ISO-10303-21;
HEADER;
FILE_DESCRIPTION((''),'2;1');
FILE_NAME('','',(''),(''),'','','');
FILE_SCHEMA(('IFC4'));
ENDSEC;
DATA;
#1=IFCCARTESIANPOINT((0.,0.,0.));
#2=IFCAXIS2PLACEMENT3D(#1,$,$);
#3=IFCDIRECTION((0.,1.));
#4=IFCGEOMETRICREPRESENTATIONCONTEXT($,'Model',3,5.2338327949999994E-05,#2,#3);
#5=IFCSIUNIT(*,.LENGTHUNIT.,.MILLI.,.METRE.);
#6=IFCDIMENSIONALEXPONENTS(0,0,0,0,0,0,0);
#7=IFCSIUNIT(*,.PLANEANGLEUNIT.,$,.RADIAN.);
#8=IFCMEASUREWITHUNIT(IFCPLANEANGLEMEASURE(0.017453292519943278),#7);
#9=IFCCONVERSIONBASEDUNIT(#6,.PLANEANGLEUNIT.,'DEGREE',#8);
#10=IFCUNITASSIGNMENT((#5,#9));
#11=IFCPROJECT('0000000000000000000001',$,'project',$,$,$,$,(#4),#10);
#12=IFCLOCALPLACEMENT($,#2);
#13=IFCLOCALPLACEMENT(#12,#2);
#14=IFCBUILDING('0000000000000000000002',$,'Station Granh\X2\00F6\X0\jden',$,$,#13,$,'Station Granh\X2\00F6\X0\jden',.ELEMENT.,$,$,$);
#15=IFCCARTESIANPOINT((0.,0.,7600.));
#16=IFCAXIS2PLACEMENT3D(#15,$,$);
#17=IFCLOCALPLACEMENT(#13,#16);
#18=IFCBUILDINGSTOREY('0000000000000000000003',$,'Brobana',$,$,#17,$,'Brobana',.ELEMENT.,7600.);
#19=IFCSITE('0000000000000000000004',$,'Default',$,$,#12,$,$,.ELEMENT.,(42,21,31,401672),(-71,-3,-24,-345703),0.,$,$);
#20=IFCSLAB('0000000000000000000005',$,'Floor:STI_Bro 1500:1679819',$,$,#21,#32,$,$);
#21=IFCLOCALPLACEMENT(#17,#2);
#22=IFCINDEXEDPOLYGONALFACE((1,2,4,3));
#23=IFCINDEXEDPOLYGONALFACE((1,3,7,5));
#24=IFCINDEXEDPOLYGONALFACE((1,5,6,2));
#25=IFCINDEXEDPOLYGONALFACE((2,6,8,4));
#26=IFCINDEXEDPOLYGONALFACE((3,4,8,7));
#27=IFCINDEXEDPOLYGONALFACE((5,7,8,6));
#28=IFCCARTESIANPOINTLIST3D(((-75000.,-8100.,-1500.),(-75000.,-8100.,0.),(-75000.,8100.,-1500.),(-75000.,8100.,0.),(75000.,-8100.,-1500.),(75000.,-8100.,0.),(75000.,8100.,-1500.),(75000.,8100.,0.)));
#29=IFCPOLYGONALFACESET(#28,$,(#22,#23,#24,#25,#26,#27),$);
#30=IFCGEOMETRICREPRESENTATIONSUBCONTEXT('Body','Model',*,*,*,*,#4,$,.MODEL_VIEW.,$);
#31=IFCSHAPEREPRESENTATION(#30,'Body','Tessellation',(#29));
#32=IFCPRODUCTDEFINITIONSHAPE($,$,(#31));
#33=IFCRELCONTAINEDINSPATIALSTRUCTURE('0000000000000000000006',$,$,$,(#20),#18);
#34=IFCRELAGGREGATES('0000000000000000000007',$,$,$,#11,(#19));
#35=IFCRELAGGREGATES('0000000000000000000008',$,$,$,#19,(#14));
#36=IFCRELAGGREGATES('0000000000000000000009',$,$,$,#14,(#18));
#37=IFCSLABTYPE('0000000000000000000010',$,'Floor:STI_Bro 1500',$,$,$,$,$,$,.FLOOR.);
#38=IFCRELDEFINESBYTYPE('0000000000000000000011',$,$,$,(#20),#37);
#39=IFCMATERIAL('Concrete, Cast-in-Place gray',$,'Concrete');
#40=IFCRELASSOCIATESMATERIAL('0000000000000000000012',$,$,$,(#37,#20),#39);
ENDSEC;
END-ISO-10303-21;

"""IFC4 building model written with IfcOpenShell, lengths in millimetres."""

from ifc_helpers import new_model, entity, si_unit, converted_unit, direction, frame, origin, place, context, subcontext, project, spatial, indexed_curve, outline, extrude, material, type_object, element, save


model = new_model("IFC4")

# Units and contexts
model_context = context("Model", 3, precision=5.2338327949999994e-05, world=origin(), true_north=direction((0.0, 1.0)))
body_context = subcontext(model_context, "Body", "Model", "MODEL_VIEW")
ifc_project = project(units=[si_unit("LENGTHUNIT", "METRE", prefix="MILLI"), converted_unit("PLANEANGLEUNIT", "DEGREE", entity("IfcPlaneAngleMeasure", 0.017453292519943278), si_unit("PLANEANGLEUNIT", "RADIAN"), dimensions=[0, 0, 0, 0, 0, 0, 0])], contexts=[model_context])

# Site, building, storey
site_placement = place(None, origin())
site = spatial("IfcSite", under=ifc_project, at=site_placement, Name="Default", CompositionType="ELEMENT", RefLatitude=(42, 21, 31, 401672), RefLongitude=(-71, -3, -24, -345703), RefElevation=0.0)
building_placement = place(site_placement, origin())
building = spatial("IfcBuilding", under=site, at=building_placement, Name="Station Granhöjden", LongName="Station Granhöjden", CompositionType="ELEMENT")
storey_placement = place(building_placement, frame((0.0, 0.0, 7600.0)))
storey = spatial("IfcBuildingStorey", under=building, at=storey_placement, Name="Brobana", LongName="Brobana", CompositionType="ELEMENT", Elevation=7600.0)

# Slab
ifc_material = material(Name="Concrete, Cast-in-Place gray", Category="Concrete")
slab_type = type_object("IfcSlabType", Name="Floor:STI_Bro 1500", PredefinedType="FLOOR", material=ifc_material)
slab_placement = place(storey_placement, origin())
element("IfcSlab", 1, at=slab_placement, inside=storey, type_object=slab_type, material=ifc_material, Name="Floor:STI_Bro 1500:1679819", context=body_context, shape_type="SweptSolid", body=[
    extrude(outline(indexed_curve([(-8100.0, -75000.0), (8100.0, -75000.0), (8100.0, 75000.0), (-8100.0, 75000.0), (-8100.0, -75000.0)], self_intersect=False)), frame((0.0, 0.0, 0.0), z_axis=(0.0, 0.0, -1.0), x_axis=(0.0, 1.0, 0.0)), (0.0, 0.0, 1.0), 1500.0),
])

save(model, "model.ifc")
